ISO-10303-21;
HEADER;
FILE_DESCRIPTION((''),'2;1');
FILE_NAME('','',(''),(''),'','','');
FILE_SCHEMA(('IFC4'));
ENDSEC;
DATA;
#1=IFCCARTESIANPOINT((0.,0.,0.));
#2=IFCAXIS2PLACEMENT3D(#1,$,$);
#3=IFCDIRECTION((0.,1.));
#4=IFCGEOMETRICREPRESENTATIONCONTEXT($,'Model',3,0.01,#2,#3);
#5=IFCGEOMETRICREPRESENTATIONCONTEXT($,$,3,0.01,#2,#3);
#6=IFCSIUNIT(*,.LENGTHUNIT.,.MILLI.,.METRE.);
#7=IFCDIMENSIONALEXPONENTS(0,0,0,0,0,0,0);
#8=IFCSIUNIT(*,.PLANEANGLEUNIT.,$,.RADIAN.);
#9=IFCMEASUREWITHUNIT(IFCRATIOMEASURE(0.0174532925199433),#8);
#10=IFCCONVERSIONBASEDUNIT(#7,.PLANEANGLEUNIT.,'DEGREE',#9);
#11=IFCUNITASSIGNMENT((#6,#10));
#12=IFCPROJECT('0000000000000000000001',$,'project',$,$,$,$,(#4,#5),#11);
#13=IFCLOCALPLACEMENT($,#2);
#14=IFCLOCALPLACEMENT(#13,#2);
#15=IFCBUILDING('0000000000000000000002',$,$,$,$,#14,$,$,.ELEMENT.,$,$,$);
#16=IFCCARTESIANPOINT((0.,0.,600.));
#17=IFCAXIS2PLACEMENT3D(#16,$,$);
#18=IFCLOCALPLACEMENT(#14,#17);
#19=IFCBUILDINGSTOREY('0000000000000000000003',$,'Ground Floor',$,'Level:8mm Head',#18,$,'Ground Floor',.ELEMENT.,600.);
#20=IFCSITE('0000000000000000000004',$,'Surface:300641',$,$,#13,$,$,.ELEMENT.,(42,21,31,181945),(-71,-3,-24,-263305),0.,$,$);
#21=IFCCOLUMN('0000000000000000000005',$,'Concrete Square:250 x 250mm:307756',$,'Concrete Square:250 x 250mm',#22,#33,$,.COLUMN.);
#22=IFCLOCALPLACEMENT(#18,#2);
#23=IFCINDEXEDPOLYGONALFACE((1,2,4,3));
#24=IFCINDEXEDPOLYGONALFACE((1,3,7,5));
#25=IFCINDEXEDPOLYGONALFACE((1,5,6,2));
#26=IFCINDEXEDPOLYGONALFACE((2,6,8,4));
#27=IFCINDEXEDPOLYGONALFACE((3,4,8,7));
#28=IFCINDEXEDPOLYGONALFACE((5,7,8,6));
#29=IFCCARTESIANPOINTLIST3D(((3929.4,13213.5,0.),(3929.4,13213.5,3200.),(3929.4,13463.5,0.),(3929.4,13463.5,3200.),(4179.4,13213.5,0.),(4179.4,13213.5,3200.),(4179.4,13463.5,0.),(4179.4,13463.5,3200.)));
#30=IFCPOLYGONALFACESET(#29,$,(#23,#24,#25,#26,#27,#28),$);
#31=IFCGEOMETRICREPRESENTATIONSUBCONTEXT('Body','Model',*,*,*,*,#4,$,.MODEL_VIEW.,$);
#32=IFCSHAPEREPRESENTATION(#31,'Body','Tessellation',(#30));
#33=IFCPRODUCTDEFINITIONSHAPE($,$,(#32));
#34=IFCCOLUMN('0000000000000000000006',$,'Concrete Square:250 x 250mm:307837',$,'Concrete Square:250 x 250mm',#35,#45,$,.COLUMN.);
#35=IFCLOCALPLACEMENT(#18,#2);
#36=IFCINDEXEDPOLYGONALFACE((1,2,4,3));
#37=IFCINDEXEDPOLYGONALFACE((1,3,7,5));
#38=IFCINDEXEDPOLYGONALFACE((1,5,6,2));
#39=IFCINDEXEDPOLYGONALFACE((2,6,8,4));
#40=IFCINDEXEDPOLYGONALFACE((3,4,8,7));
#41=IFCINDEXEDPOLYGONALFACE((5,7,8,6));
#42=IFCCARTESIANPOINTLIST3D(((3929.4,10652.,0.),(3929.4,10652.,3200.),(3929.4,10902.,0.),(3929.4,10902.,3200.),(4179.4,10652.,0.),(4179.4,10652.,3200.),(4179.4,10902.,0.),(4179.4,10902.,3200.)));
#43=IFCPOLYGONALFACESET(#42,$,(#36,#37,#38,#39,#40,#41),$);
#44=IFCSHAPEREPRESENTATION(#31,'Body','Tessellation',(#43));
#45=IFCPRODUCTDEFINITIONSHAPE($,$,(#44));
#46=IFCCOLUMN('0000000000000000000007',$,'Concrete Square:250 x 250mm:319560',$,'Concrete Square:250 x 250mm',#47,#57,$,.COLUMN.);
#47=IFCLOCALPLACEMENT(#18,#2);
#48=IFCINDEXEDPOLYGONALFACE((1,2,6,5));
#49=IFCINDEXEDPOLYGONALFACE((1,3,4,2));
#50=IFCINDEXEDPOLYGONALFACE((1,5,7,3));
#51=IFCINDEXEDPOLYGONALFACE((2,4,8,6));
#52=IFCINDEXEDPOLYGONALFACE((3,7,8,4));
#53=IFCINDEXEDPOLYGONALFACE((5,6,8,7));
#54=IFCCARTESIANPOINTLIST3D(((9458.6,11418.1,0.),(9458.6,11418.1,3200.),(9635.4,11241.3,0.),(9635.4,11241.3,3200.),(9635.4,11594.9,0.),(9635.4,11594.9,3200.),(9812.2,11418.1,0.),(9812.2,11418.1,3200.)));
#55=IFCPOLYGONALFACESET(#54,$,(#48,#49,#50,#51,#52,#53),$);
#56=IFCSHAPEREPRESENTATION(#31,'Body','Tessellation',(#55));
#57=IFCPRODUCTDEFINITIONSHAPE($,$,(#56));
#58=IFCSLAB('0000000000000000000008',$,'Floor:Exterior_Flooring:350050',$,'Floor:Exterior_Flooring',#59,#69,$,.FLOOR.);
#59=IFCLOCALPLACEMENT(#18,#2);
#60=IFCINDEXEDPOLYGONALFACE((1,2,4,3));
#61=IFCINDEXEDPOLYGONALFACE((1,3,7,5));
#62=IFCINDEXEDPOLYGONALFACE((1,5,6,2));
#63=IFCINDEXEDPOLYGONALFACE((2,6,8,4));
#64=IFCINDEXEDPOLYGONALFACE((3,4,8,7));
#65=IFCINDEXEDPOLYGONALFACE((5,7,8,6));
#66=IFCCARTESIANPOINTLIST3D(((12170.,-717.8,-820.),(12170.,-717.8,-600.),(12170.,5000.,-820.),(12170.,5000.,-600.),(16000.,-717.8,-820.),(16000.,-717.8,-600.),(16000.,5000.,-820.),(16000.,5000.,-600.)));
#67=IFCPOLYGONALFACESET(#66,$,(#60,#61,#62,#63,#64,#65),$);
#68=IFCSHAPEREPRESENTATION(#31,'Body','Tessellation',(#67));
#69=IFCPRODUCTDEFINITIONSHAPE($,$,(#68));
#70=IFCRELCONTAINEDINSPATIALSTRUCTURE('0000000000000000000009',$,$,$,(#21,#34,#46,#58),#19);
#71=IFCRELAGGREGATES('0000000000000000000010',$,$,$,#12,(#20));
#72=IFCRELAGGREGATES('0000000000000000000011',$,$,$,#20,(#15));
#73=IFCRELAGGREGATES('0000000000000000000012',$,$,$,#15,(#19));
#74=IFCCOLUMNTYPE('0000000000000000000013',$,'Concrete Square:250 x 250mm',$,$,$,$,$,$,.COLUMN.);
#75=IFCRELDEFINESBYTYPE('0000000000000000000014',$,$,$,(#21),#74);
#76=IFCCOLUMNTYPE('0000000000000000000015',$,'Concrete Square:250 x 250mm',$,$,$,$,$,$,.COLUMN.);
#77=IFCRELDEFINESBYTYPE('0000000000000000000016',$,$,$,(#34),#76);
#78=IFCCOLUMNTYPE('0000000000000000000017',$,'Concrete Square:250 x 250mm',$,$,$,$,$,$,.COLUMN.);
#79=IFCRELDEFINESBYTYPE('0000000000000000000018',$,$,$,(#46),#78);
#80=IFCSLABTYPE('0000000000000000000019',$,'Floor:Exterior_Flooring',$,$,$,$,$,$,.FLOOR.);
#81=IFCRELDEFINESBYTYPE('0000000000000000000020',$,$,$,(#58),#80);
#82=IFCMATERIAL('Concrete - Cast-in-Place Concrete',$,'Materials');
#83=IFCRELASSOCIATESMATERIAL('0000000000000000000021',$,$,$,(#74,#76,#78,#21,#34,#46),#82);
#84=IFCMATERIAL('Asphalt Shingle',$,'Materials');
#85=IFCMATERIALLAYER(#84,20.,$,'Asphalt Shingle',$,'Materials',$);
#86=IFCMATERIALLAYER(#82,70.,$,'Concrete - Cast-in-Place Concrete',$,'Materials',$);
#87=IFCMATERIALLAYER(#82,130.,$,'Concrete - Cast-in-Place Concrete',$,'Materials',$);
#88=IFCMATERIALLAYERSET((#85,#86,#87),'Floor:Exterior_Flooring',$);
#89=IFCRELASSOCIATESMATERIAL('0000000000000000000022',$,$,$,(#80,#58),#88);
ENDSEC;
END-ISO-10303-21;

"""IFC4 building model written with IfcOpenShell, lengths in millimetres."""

from ifc_helpers import new_model, entity, si_unit, converted_unit, direction, frame, frame_2d, origin, place, context, subcontext, project, spatial, rectangle, extrude, source, transform, mapped, material, layer, layer_set, layer_usage, material_profile, profile_set, profile_usage, type_object, type_shapes, element, save


model = new_model("IFC4")

# Units and contexts
model_context = context("Model", 3, precision=0.01, world=origin(), true_north=direction((0.0, 1.0)))
context_of_model = context(None, 3, precision=0.01, world=origin(), true_north=direction((0.0, 1.0)))
body_context = subcontext(model_context, "Body", "Model", "MODEL_VIEW")
ifc_project = project(units=[si_unit("LENGTHUNIT", "METRE", prefix="MILLI"), converted_unit("PLANEANGLEUNIT", "DEGREE", entity("IfcRatioMeasure", 0.0174532925199433), si_unit("PLANEANGLEUNIT", "RADIAN"), dimensions=[0, 0, 0, 0, 0, 0, 0])], contexts=[model_context, context_of_model])

# Site, building, storey
site_placement = place(None, origin())
site = spatial("IfcSite", under=ifc_project, at=site_placement, Name="Surface:300641", CompositionType="ELEMENT", RefLatitude=(42, 21, 31, 181945), RefLongitude=(-71, -3, -24, -263305), RefElevation=0.0)
building_placement = place(site_placement, origin())
building = spatial("IfcBuilding", under=site, at=building_placement, CompositionType="ELEMENT")
storey_placement = place(building_placement, frame((0.0, 0.0, 600.0)))
storey = spatial("IfcBuildingStorey", under=building, at=storey_placement, Name="Ground Floor", ObjectType="Level:8mm Head", LongName="Ground Floor", CompositionType="ELEMENT", Elevation=600.0)

# Columns
ifc_material_1 = material(Name="Concrete - Cast-in-Place Concrete", Category="Materials")
ifc_material_profile_1 = material_profile(ifc_material_1, rectangle(XDim=250.0, YDim=250.0, at=frame_2d((0.0, 0.0), x_axis=(1.0, 0.0))), Name="250 x 250mm")
ifc_profile_set_1 = profile_set([ifc_material_profile_1], Name="250 x 250mm")
ifc_profile_usage_1 = profile_usage(ifc_profile_set_1)
column_type_1 = type_object("IfcColumnType", Name="Concrete Square:250 x 250mm", PredefinedType="COLUMN", material=ifc_profile_set_1)
shared_shape_1 = source(origin(), body_context, "Body", "SweptSolid", [
    extrude(rectangle(XDim=250.0, YDim=250.0, at=frame_2d((0.0, 0.0), x_axis=(1.0, 0.0))), frame((4054.4, 13338.5, 600.0), z_axis=(0.0, 0.0, 1.0), x_axis=(0.0, -1.0, 0.0)), (0.0, 0.0, 1.0), 3200.0),
])
type_shapes(column_type_1, [shared_shape_1])
column_1_placement = place(storey_placement, frame((0.0, 0.0, -600.0)))
element("IfcColumn", 1, at=column_1_placement, inside=storey, type_object=column_type_1, material=ifc_profile_usage_1, Name="Concrete Square:250 x 250mm:307756", ObjectType="Concrete Square:250 x 250mm", PredefinedType="COLUMN", context=body_context, shape_type="MappedRepresentation", body=[
    mapped(shared_shape_1, transform((0.0, 0.0, 0.0), scale=1.0)),
])
ifc_profile_usage_2 = profile_usage(ifc_profile_set_1)
column_type_2 = type_object("IfcColumnType", Name="Concrete Square:250 x 250mm", PredefinedType="COLUMN", material=ifc_profile_set_1)
shared_shape_2 = source(origin(), body_context, "Body", "SweptSolid", [
    extrude(rectangle(XDim=250.0, YDim=250.0, at=frame_2d((0.0, 0.0), x_axis=(1.0, 0.0))), frame((4054.4, 10777.0, 600.0), z_axis=(0.0, 0.0, 1.0), x_axis=(0.0, -1.0, 0.0)), (0.0, 0.0, 1.0), 3200.0),
])
type_shapes(column_type_2, [shared_shape_2])
column_2_placement = place(storey_placement, frame((0.0, 0.0, -600.0)))
element("IfcColumn", 2, at=column_2_placement, inside=storey, type_object=column_type_2, material=ifc_profile_usage_2, Name="Concrete Square:250 x 250mm:307837", ObjectType="Concrete Square:250 x 250mm", PredefinedType="COLUMN", context=body_context, shape_type="MappedRepresentation", body=[
    mapped(shared_shape_2, transform((0.0, 0.0, 0.0), scale=1.0)),
])
ifc_profile_usage_3 = profile_usage(ifc_profile_set_1)
column_type_3 = type_object("IfcColumnType", Name="Concrete Square:250 x 250mm", PredefinedType="COLUMN", material=ifc_profile_set_1)
shared_shape_3 = source(origin(), body_context, "Body", "SweptSolid", [
    extrude(rectangle(XDim=250.0, YDim=250.0, at=frame_2d((0.0, 0.0), x_axis=(1.0, 0.0))), frame((9635.4, 11418.1, 600.0), z_axis=(0.0, 0.0, 1.0), x_axis=(-0.707107, 0.707107, 0.0)), (0.0, 0.0, 1.0), 3200.0),
])
type_shapes(column_type_3, [shared_shape_3])
column_3_placement = place(storey_placement, frame((0.0, 0.0, -600.0)))
element("IfcColumn", 3, at=column_3_placement, inside=storey, type_object=column_type_3, material=ifc_profile_usage_3, Name="Concrete Square:250 x 250mm:319560", ObjectType="Concrete Square:250 x 250mm", PredefinedType="COLUMN", context=body_context, shape_type="MappedRepresentation", body=[
    mapped(shared_shape_3, transform((0.0, 0.0, 0.0), scale=1.0)),
])

# Slab
ifc_material_2 = material(Name="Asphalt Shingle", Category="Materials")
ifc_layer_1 = layer(ifc_material_2, 20.0, Name="Asphalt Shingle", Category="Materials")
ifc_layer_2 = layer(ifc_material_1, 70.0, Name="Concrete - Cast-in-Place Concrete", Category="Materials")
ifc_layer_3 = layer(ifc_material_1, 130.0, Name="Concrete - Cast-in-Place Concrete", Category="Materials")
ifc_layer_set_1 = layer_set([ifc_layer_1, ifc_layer_2, ifc_layer_3], Name="Floor:Exterior_Flooring")
ifc_layer_usage_1 = layer_usage(ifc_layer_set_1, "AXIS3", "POSITIVE", 0.0)
slab_type_1 = type_object("IfcSlabType", Name="Floor:Exterior_Flooring", PredefinedType="FLOOR", material=ifc_layer_set_1)
slab_1_placement = place(storey_placement, origin())
element("IfcSlab", 4, at=slab_1_placement, inside=storey, type_object=slab_type_1, material=ifc_layer_usage_1, Name="Floor:Exterior_Flooring:350050", ObjectType="Floor:Exterior_Flooring", PredefinedType="FLOOR", context=body_context, shape_type="SweptSolid", body=[
    extrude(rectangle(XDim=5717.8, YDim=3830.0, at=frame_2d((0.0, 0.0), x_axis=(1.0, 0.0))), frame((14085.0, 2141.1, -600.0), z_axis=(0.0, 0.0, -1.0), x_axis=(0.0, 1.0, 0.0)), (0.0, 0.0, 1.0), 220.0),
])

save(model, "model.ifc")
